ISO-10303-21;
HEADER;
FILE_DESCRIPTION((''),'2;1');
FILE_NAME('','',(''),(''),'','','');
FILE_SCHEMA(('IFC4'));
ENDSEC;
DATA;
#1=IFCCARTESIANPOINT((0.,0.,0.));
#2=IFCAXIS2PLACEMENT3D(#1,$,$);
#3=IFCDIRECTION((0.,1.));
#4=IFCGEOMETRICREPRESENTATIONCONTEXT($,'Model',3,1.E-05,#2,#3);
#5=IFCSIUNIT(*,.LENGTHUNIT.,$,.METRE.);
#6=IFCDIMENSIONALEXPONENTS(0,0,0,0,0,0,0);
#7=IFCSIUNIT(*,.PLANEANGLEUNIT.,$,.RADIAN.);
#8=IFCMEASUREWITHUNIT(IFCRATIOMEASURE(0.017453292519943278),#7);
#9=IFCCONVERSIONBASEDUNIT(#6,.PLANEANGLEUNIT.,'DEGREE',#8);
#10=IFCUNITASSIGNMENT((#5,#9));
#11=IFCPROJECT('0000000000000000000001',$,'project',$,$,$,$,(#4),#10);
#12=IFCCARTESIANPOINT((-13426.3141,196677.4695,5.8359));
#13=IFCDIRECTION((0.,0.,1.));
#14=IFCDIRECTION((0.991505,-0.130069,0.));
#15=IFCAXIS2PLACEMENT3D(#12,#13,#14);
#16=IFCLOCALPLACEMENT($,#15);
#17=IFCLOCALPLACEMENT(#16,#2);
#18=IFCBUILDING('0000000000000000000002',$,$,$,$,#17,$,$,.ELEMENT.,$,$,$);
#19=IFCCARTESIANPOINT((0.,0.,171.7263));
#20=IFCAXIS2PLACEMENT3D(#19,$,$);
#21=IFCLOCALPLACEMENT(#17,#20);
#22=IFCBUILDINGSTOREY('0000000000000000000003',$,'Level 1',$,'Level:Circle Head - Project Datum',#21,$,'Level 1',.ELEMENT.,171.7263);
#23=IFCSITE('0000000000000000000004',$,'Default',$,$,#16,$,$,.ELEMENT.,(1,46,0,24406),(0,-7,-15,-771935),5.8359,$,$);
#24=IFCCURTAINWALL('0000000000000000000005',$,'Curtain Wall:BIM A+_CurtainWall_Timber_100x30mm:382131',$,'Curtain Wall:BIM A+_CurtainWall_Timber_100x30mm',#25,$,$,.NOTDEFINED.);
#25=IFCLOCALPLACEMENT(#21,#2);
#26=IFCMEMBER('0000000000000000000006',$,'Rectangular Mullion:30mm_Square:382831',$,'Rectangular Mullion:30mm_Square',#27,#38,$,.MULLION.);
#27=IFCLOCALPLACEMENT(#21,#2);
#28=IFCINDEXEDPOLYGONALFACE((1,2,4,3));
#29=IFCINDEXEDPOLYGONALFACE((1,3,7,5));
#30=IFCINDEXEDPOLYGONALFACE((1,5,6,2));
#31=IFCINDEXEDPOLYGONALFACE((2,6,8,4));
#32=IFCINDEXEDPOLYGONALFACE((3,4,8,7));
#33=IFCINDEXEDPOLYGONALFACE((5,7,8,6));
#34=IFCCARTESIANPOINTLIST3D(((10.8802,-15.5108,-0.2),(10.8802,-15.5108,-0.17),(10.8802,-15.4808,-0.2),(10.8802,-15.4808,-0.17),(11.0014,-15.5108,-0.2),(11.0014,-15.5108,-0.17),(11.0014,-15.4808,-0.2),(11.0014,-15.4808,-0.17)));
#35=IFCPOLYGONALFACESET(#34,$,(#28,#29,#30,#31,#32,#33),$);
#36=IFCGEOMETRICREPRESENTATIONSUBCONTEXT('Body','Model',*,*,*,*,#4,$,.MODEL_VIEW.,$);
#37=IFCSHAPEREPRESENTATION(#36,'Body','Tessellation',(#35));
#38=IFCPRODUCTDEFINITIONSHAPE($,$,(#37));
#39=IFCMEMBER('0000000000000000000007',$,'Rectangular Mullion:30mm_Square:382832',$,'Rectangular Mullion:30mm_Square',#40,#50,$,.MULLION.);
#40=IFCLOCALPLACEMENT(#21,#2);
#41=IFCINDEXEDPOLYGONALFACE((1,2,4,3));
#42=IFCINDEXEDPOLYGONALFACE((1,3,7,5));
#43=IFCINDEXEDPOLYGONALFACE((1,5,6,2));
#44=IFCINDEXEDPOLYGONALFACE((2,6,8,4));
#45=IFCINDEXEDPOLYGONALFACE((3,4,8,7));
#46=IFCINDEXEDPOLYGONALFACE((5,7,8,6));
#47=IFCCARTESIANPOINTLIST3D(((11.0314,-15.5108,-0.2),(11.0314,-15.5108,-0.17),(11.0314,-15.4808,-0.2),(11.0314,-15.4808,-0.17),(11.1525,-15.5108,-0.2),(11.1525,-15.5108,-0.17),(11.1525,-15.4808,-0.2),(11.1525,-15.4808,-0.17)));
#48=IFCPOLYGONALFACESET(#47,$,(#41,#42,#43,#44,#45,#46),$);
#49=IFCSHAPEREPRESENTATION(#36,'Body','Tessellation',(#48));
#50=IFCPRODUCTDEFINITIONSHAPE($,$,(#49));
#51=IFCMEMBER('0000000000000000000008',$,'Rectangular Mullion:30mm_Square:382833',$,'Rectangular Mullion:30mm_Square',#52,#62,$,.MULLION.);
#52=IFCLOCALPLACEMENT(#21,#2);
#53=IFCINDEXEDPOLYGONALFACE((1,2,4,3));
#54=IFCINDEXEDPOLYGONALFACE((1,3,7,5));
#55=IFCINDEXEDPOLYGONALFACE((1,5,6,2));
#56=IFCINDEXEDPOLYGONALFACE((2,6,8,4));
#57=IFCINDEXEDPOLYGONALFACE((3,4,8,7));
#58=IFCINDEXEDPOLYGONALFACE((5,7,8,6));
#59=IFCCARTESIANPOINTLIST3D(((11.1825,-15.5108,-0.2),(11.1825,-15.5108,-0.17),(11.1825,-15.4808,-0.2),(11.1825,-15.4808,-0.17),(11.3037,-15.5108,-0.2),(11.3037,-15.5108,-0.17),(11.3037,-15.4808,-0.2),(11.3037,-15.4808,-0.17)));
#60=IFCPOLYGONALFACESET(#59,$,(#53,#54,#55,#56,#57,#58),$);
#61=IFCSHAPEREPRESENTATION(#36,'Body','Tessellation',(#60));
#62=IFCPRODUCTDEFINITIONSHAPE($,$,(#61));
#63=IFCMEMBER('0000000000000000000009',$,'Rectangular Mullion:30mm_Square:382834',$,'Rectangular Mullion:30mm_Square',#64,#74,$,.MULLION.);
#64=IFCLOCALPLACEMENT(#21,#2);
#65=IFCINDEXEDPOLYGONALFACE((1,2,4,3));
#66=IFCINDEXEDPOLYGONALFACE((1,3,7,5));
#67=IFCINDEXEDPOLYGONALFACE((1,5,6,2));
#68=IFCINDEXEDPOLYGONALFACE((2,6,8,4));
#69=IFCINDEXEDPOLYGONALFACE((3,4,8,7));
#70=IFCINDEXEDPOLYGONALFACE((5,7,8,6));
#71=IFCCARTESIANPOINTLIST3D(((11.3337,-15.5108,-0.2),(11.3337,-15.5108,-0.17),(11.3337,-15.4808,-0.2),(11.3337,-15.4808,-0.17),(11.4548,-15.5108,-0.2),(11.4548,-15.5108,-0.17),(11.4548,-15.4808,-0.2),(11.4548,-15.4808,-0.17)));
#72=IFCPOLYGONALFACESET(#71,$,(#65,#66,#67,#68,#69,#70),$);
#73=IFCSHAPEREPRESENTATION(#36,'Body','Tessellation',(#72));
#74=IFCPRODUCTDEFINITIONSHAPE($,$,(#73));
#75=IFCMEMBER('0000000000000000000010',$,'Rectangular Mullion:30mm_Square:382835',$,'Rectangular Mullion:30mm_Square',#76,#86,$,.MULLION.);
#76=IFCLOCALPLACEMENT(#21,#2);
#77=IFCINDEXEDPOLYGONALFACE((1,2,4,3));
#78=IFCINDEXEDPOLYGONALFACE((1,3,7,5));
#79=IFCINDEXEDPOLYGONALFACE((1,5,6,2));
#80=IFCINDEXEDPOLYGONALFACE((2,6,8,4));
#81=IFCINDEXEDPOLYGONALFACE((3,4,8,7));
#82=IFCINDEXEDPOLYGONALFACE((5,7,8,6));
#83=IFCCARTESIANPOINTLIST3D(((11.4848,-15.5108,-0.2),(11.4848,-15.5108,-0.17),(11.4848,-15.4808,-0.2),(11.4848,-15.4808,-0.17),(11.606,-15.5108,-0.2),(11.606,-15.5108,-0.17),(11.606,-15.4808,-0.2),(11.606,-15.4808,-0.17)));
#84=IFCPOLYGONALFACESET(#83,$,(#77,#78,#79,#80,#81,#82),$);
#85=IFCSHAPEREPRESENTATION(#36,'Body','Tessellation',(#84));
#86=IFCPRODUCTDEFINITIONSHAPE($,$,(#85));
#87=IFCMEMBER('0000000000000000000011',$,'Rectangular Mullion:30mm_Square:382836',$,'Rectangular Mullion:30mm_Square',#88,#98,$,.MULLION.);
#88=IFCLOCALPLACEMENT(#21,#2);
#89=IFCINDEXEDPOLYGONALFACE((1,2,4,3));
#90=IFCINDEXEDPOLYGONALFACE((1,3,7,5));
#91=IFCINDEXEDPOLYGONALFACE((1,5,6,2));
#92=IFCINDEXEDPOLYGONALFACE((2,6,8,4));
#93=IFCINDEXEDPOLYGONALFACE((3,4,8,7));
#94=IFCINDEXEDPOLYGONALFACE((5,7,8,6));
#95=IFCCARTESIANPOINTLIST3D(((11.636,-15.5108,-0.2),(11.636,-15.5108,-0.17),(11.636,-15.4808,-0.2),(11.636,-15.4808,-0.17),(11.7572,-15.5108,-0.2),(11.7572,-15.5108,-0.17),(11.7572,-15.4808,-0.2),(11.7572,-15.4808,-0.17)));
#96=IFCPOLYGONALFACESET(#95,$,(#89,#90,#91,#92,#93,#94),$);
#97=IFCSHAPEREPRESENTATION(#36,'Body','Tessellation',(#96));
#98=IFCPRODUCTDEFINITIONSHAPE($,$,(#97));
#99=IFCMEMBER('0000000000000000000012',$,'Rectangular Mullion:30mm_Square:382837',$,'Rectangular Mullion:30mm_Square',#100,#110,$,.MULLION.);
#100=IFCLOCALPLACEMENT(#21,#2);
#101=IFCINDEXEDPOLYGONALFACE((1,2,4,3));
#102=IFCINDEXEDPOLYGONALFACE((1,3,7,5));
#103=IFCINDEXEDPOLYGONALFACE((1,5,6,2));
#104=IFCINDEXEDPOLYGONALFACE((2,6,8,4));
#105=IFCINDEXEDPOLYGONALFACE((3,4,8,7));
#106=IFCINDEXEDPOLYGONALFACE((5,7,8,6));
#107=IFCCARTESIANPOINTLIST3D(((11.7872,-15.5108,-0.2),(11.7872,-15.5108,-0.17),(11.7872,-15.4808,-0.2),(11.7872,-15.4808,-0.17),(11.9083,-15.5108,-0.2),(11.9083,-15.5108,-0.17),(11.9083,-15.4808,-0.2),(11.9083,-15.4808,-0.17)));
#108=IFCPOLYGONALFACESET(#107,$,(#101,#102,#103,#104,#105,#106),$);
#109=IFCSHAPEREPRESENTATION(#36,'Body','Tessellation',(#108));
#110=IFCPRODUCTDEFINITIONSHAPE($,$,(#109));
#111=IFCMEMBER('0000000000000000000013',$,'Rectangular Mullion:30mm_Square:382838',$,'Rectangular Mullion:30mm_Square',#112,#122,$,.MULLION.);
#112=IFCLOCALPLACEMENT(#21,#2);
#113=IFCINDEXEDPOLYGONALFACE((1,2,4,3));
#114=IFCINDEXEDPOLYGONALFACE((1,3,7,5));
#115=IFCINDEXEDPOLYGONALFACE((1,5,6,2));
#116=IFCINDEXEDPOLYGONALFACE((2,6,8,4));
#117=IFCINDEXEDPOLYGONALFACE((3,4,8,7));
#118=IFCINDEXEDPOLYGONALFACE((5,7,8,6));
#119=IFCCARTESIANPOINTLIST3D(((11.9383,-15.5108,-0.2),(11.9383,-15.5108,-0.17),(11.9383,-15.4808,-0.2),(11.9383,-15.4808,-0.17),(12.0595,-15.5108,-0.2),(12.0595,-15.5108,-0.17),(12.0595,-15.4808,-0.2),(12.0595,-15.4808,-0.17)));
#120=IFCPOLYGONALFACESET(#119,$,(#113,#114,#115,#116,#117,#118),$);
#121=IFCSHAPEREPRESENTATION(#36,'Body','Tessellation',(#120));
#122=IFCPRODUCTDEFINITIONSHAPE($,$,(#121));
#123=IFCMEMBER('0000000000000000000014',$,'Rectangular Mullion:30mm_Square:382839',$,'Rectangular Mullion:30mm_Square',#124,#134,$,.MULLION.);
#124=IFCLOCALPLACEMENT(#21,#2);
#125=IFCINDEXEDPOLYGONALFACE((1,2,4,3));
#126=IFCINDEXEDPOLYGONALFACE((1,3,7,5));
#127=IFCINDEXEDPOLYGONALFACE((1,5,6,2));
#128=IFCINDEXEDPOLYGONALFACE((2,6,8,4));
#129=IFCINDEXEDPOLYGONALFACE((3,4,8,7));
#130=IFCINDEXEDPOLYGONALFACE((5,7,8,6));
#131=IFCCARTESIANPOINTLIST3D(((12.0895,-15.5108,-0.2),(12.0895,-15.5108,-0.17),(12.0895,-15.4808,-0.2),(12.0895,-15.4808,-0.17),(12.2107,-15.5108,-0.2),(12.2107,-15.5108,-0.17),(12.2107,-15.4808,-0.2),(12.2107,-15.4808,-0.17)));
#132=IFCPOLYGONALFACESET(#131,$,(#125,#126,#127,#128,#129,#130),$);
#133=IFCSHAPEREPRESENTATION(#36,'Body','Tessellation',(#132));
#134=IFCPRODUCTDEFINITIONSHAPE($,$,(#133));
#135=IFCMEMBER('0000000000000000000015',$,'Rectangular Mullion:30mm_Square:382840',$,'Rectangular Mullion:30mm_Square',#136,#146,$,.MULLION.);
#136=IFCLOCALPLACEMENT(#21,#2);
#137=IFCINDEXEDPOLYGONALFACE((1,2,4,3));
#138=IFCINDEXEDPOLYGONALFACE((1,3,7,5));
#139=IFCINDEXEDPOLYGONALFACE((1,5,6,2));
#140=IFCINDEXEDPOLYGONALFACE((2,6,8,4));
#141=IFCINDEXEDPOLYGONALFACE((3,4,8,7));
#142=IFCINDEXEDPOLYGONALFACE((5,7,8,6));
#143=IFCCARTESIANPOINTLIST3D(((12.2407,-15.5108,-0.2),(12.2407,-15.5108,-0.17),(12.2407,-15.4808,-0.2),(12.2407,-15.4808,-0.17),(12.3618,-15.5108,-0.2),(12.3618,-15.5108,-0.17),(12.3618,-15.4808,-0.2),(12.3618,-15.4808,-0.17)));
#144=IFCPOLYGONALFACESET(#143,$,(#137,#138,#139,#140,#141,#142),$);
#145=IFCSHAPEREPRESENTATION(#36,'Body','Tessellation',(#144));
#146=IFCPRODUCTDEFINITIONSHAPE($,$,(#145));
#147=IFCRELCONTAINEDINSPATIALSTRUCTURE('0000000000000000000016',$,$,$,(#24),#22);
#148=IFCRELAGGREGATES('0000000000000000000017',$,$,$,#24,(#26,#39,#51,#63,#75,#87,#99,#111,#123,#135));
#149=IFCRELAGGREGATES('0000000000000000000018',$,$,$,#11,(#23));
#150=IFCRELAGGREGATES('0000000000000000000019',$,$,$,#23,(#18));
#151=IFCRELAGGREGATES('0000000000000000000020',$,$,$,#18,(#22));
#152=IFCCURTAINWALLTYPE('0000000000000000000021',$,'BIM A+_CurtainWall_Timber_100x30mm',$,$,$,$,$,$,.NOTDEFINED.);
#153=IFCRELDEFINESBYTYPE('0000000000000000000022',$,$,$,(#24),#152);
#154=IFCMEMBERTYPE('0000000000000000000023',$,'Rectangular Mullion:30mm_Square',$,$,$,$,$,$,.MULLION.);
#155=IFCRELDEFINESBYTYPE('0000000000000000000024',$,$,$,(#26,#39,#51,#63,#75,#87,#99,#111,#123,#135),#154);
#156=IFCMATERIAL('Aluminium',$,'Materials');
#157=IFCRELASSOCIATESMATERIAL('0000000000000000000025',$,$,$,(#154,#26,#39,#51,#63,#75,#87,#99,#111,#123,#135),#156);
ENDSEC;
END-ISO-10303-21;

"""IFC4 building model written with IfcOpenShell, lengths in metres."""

from ifc_helpers import new_model, entity, si_unit, converted_unit, direction, frame, origin, place, context, subcontext, project, spatial, indexed_curve, outline, extrude, source, transform, mapped, material, type_object, type_shapes, element, aggregate, save


model = new_model("IFC4")

# Units and contexts
model_context = context("Model", 3, precision=1e-05, world=origin(), true_north=direction((0.0, 1.0)))
body_context = subcontext(model_context, "Body", "Model", "MODEL_VIEW")
ifc_project = project(units=[si_unit("LENGTHUNIT", "METRE"), converted_unit("PLANEANGLEUNIT", "DEGREE", entity("IfcRatioMeasure", 0.017453292519943278), si_unit("PLANEANGLEUNIT", "RADIAN"), dimensions=[0, 0, 0, 0, 0, 0, 0])], contexts=[model_context])

# Site, building, storey
site_placement = place(None, frame((-13426.3141, 196677.4695, 5.8359), z_axis=(0.0, 0.0, 1.0), x_axis=(0.991505, -0.130069, 0.0)))
site = spatial("IfcSite", under=ifc_project, at=site_placement, Name="Default", CompositionType="ELEMENT", RefLatitude=(1, 46, 0, 24406), RefLongitude=(0, -7, -15, -771935), RefElevation=5.8359)
building_placement = place(site_placement, origin())
building = spatial("IfcBuilding", under=site, at=building_placement, CompositionType="ELEMENT")
storey_placement = place(building_placement, frame((0.0, 0.0, 171.7263)))
storey = spatial("IfcBuildingStorey", under=building, at=storey_placement, Name="Level 1", ObjectType="Level:Circle Head - Project Datum", LongName="Level 1", CompositionType="ELEMENT", Elevation=171.7263)

# Curtain wall, members
curtain_wall_type = type_object("IfcCurtainWallType", Name="BIM A+_CurtainWall_Timber_100x30mm", PredefinedType="NOTDEFINED")
curtain_wall_placement = place(storey_placement, frame((0.0, 0.0, -171.7263)))
curtain_wall = element("IfcCurtainWall", 1, at=curtain_wall_placement, inside=storey, type_object=curtain_wall_type, Name="Curtain Wall:BIM A+_CurtainWall_Timber_100x30mm:382131", ObjectType="Curtain Wall:BIM A+_CurtainWall_Timber_100x30mm", PredefinedType="NOTDEFINED")
ifc_material_1 = material(Name="Aluminium", Category="Materials")
member_type = type_object("IfcMemberType", Name="Rectangular Mullion:30mm_Square", PredefinedType="MULLION", material=ifc_material_1)
shared_shape_1 = source(origin(), body_context, "Body", "SweptSolid", [
    extrude(outline(indexed_curve([(-0.015, -0.015), (0.015, -0.015), (0.015, 0.015), (-0.015, 0.015), (-0.015, -0.015)], self_intersect=False)), frame((-0.015, 0.0, -0.1212), z_axis=(0.0, 0.0, 1.0), x_axis=(0.0, -1.0, 0.0)), (0.0, 0.0, 1.0), 0.1212),
])
type_shapes(member_type, [shared_shape_1])
member_1_placement = place(curtain_wall_placement, frame((10.8802, -15.4958, 171.5263), z_axis=(-1.0, 0.0, 0.0), x_axis=(0.0, 0.0, -1.0)))
member_1 = element("IfcMember", 2, at=member_1_placement, type_object=member_type, material=ifc_material_1, Name="Rectangular Mullion:30mm_Square:382831", ObjectType="Rectangular Mullion:30mm_Square", PredefinedType="MULLION", context=body_context, shape_type="MappedRepresentation", body=[
    mapped(shared_shape_1, transform((0.0, 0.0, 0.0), scale=1.0)),
])
member_2_placement = place(curtain_wall_placement, frame((11.0314, -15.4958, 171.5263), z_axis=(-1.0, 0.0, 0.0), x_axis=(0.0, 0.0, -1.0)))
member_2 = element("IfcMember", 3, at=member_2_placement, type_object=member_type, material=ifc_material_1, Name="Rectangular Mullion:30mm_Square:382832", ObjectType="Rectangular Mullion:30mm_Square", PredefinedType="MULLION", context=body_context, shape_type="MappedRepresentation", body=[
    mapped(shared_shape_1, transform((0.0, 0.0, 0.0), scale=1.0)),
])
member_3_placement = place(curtain_wall_placement, frame((11.1825, -15.4958, 171.5263), z_axis=(-1.0, 0.0, 0.0), x_axis=(0.0, 0.0, -1.0)))
member_3 = element("IfcMember", 4, at=member_3_placement, type_object=member_type, material=ifc_material_1, Name="Rectangular Mullion:30mm_Square:382833", ObjectType="Rectangular Mullion:30mm_Square", PredefinedType="MULLION", context=body_context, shape_type="MappedRepresentation", body=[
    mapped(shared_shape_1, transform((0.0, 0.0, 0.0), scale=1.0)),
])
member_4_placement = place(curtain_wall_placement, frame((11.3337, -15.4958, 171.5263), z_axis=(-1.0, 0.0, 0.0), x_axis=(0.0, 0.0, -1.0)))
member_4 = element("IfcMember", 5, at=member_4_placement, type_object=member_type, material=ifc_material_1, Name="Rectangular Mullion:30mm_Square:382834", ObjectType="Rectangular Mullion:30mm_Square", PredefinedType="MULLION", context=body_context, shape_type="MappedRepresentation", body=[
    mapped(shared_shape_1, transform((0.0, 0.0, 0.0), scale=1.0)),
])
member_5_placement = place(curtain_wall_placement, frame((11.4848, -15.4958, 171.5263), z_axis=(-1.0, 0.0, 0.0), x_axis=(0.0, 0.0, -1.0)))
member_5 = element("IfcMember", 6, at=member_5_placement, type_object=member_type, material=ifc_material_1, Name="Rectangular Mullion:30mm_Square:382835", ObjectType="Rectangular Mullion:30mm_Square", PredefinedType="MULLION", context=body_context, shape_type="MappedRepresentation", body=[
    mapped(shared_shape_1, transform((0.0, 0.0, 0.0), scale=1.0)),
])
member_6_placement = place(curtain_wall_placement, frame((11.636, -15.4958, 171.5263), z_axis=(-1.0, 0.0, 0.0), x_axis=(0.0, 0.0, -1.0)))
member_6 = element("IfcMember", 7, at=member_6_placement, type_object=member_type, material=ifc_material_1, Name="Rectangular Mullion:30mm_Square:382836", ObjectType="Rectangular Mullion:30mm_Square", PredefinedType="MULLION", context=body_context, shape_type="MappedRepresentation", body=[
    mapped(shared_shape_1, transform((0.0, 0.0, 0.0), scale=1.0)),
])
member_7_placement = place(curtain_wall_placement, frame((11.7872, -15.4958, 171.5263), z_axis=(-1.0, 0.0, 0.0), x_axis=(0.0, 0.0, -1.0)))
member_7 = element("IfcMember", 8, at=member_7_placement, type_object=member_type, material=ifc_material_1, Name="Rectangular Mullion:30mm_Square:382837", ObjectType="Rectangular Mullion:30mm_Square", PredefinedType="MULLION", context=body_context, shape_type="MappedRepresentation", body=[
    mapped(shared_shape_1, transform((0.0, 0.0, 0.0), scale=1.0)),
])
member_8_placement = place(curtain_wall_placement, frame((11.9383, -15.4958, 171.5263), z_axis=(-1.0, 0.0, 0.0), x_axis=(0.0, 0.0, -1.0)))
member_8 = element("IfcMember", 9, at=member_8_placement, type_object=member_type, material=ifc_material_1, Name="Rectangular Mullion:30mm_Square:382838", ObjectType="Rectangular Mullion:30mm_Square", PredefinedType="MULLION", context=body_context, shape_type="MappedRepresentation", body=[
    mapped(shared_shape_1, transform((0.0, 0.0, 0.0), scale=1.0)),
])
member_9_placement = place(curtain_wall_placement, frame((12.0895, -15.4958, 171.5263), z_axis=(-1.0, 0.0, 0.0), x_axis=(0.0, 0.0, -1.0)))
member_9 = element("IfcMember", 10, at=member_9_placement, type_object=member_type, material=ifc_material_1, Name="Rectangular Mullion:30mm_Square:382839", ObjectType="Rectangular Mullion:30mm_Square", PredefinedType="MULLION", context=body_context, shape_type="MappedRepresentation", body=[
    mapped(shared_shape_1, transform((0.0, 0.0, 0.0), scale=1.0)),
])
member_10_placement = place(curtain_wall_placement, frame((12.2407, -15.4958, 171.5263), z_axis=(-1.0, 0.0, 0.0), x_axis=(0.0, 0.0, -1.0)))
member_10 = element("IfcMember", 11, at=member_10_placement, type_object=member_type, material=ifc_material_1, Name="Rectangular Mullion:30mm_Square:382840", ObjectType="Rectangular Mullion:30mm_Square", PredefinedType="MULLION", context=body_context, shape_type="MappedRepresentation", body=[
    mapped(shared_shape_1, transform((0.0, 0.0, 0.0), scale=1.0)),
])
aggregate(curtain_wall, [member_1, member_2, member_3, member_4, member_5, member_6, member_7, member_8, member_9, member_10])

save(model, "model.ifc")
